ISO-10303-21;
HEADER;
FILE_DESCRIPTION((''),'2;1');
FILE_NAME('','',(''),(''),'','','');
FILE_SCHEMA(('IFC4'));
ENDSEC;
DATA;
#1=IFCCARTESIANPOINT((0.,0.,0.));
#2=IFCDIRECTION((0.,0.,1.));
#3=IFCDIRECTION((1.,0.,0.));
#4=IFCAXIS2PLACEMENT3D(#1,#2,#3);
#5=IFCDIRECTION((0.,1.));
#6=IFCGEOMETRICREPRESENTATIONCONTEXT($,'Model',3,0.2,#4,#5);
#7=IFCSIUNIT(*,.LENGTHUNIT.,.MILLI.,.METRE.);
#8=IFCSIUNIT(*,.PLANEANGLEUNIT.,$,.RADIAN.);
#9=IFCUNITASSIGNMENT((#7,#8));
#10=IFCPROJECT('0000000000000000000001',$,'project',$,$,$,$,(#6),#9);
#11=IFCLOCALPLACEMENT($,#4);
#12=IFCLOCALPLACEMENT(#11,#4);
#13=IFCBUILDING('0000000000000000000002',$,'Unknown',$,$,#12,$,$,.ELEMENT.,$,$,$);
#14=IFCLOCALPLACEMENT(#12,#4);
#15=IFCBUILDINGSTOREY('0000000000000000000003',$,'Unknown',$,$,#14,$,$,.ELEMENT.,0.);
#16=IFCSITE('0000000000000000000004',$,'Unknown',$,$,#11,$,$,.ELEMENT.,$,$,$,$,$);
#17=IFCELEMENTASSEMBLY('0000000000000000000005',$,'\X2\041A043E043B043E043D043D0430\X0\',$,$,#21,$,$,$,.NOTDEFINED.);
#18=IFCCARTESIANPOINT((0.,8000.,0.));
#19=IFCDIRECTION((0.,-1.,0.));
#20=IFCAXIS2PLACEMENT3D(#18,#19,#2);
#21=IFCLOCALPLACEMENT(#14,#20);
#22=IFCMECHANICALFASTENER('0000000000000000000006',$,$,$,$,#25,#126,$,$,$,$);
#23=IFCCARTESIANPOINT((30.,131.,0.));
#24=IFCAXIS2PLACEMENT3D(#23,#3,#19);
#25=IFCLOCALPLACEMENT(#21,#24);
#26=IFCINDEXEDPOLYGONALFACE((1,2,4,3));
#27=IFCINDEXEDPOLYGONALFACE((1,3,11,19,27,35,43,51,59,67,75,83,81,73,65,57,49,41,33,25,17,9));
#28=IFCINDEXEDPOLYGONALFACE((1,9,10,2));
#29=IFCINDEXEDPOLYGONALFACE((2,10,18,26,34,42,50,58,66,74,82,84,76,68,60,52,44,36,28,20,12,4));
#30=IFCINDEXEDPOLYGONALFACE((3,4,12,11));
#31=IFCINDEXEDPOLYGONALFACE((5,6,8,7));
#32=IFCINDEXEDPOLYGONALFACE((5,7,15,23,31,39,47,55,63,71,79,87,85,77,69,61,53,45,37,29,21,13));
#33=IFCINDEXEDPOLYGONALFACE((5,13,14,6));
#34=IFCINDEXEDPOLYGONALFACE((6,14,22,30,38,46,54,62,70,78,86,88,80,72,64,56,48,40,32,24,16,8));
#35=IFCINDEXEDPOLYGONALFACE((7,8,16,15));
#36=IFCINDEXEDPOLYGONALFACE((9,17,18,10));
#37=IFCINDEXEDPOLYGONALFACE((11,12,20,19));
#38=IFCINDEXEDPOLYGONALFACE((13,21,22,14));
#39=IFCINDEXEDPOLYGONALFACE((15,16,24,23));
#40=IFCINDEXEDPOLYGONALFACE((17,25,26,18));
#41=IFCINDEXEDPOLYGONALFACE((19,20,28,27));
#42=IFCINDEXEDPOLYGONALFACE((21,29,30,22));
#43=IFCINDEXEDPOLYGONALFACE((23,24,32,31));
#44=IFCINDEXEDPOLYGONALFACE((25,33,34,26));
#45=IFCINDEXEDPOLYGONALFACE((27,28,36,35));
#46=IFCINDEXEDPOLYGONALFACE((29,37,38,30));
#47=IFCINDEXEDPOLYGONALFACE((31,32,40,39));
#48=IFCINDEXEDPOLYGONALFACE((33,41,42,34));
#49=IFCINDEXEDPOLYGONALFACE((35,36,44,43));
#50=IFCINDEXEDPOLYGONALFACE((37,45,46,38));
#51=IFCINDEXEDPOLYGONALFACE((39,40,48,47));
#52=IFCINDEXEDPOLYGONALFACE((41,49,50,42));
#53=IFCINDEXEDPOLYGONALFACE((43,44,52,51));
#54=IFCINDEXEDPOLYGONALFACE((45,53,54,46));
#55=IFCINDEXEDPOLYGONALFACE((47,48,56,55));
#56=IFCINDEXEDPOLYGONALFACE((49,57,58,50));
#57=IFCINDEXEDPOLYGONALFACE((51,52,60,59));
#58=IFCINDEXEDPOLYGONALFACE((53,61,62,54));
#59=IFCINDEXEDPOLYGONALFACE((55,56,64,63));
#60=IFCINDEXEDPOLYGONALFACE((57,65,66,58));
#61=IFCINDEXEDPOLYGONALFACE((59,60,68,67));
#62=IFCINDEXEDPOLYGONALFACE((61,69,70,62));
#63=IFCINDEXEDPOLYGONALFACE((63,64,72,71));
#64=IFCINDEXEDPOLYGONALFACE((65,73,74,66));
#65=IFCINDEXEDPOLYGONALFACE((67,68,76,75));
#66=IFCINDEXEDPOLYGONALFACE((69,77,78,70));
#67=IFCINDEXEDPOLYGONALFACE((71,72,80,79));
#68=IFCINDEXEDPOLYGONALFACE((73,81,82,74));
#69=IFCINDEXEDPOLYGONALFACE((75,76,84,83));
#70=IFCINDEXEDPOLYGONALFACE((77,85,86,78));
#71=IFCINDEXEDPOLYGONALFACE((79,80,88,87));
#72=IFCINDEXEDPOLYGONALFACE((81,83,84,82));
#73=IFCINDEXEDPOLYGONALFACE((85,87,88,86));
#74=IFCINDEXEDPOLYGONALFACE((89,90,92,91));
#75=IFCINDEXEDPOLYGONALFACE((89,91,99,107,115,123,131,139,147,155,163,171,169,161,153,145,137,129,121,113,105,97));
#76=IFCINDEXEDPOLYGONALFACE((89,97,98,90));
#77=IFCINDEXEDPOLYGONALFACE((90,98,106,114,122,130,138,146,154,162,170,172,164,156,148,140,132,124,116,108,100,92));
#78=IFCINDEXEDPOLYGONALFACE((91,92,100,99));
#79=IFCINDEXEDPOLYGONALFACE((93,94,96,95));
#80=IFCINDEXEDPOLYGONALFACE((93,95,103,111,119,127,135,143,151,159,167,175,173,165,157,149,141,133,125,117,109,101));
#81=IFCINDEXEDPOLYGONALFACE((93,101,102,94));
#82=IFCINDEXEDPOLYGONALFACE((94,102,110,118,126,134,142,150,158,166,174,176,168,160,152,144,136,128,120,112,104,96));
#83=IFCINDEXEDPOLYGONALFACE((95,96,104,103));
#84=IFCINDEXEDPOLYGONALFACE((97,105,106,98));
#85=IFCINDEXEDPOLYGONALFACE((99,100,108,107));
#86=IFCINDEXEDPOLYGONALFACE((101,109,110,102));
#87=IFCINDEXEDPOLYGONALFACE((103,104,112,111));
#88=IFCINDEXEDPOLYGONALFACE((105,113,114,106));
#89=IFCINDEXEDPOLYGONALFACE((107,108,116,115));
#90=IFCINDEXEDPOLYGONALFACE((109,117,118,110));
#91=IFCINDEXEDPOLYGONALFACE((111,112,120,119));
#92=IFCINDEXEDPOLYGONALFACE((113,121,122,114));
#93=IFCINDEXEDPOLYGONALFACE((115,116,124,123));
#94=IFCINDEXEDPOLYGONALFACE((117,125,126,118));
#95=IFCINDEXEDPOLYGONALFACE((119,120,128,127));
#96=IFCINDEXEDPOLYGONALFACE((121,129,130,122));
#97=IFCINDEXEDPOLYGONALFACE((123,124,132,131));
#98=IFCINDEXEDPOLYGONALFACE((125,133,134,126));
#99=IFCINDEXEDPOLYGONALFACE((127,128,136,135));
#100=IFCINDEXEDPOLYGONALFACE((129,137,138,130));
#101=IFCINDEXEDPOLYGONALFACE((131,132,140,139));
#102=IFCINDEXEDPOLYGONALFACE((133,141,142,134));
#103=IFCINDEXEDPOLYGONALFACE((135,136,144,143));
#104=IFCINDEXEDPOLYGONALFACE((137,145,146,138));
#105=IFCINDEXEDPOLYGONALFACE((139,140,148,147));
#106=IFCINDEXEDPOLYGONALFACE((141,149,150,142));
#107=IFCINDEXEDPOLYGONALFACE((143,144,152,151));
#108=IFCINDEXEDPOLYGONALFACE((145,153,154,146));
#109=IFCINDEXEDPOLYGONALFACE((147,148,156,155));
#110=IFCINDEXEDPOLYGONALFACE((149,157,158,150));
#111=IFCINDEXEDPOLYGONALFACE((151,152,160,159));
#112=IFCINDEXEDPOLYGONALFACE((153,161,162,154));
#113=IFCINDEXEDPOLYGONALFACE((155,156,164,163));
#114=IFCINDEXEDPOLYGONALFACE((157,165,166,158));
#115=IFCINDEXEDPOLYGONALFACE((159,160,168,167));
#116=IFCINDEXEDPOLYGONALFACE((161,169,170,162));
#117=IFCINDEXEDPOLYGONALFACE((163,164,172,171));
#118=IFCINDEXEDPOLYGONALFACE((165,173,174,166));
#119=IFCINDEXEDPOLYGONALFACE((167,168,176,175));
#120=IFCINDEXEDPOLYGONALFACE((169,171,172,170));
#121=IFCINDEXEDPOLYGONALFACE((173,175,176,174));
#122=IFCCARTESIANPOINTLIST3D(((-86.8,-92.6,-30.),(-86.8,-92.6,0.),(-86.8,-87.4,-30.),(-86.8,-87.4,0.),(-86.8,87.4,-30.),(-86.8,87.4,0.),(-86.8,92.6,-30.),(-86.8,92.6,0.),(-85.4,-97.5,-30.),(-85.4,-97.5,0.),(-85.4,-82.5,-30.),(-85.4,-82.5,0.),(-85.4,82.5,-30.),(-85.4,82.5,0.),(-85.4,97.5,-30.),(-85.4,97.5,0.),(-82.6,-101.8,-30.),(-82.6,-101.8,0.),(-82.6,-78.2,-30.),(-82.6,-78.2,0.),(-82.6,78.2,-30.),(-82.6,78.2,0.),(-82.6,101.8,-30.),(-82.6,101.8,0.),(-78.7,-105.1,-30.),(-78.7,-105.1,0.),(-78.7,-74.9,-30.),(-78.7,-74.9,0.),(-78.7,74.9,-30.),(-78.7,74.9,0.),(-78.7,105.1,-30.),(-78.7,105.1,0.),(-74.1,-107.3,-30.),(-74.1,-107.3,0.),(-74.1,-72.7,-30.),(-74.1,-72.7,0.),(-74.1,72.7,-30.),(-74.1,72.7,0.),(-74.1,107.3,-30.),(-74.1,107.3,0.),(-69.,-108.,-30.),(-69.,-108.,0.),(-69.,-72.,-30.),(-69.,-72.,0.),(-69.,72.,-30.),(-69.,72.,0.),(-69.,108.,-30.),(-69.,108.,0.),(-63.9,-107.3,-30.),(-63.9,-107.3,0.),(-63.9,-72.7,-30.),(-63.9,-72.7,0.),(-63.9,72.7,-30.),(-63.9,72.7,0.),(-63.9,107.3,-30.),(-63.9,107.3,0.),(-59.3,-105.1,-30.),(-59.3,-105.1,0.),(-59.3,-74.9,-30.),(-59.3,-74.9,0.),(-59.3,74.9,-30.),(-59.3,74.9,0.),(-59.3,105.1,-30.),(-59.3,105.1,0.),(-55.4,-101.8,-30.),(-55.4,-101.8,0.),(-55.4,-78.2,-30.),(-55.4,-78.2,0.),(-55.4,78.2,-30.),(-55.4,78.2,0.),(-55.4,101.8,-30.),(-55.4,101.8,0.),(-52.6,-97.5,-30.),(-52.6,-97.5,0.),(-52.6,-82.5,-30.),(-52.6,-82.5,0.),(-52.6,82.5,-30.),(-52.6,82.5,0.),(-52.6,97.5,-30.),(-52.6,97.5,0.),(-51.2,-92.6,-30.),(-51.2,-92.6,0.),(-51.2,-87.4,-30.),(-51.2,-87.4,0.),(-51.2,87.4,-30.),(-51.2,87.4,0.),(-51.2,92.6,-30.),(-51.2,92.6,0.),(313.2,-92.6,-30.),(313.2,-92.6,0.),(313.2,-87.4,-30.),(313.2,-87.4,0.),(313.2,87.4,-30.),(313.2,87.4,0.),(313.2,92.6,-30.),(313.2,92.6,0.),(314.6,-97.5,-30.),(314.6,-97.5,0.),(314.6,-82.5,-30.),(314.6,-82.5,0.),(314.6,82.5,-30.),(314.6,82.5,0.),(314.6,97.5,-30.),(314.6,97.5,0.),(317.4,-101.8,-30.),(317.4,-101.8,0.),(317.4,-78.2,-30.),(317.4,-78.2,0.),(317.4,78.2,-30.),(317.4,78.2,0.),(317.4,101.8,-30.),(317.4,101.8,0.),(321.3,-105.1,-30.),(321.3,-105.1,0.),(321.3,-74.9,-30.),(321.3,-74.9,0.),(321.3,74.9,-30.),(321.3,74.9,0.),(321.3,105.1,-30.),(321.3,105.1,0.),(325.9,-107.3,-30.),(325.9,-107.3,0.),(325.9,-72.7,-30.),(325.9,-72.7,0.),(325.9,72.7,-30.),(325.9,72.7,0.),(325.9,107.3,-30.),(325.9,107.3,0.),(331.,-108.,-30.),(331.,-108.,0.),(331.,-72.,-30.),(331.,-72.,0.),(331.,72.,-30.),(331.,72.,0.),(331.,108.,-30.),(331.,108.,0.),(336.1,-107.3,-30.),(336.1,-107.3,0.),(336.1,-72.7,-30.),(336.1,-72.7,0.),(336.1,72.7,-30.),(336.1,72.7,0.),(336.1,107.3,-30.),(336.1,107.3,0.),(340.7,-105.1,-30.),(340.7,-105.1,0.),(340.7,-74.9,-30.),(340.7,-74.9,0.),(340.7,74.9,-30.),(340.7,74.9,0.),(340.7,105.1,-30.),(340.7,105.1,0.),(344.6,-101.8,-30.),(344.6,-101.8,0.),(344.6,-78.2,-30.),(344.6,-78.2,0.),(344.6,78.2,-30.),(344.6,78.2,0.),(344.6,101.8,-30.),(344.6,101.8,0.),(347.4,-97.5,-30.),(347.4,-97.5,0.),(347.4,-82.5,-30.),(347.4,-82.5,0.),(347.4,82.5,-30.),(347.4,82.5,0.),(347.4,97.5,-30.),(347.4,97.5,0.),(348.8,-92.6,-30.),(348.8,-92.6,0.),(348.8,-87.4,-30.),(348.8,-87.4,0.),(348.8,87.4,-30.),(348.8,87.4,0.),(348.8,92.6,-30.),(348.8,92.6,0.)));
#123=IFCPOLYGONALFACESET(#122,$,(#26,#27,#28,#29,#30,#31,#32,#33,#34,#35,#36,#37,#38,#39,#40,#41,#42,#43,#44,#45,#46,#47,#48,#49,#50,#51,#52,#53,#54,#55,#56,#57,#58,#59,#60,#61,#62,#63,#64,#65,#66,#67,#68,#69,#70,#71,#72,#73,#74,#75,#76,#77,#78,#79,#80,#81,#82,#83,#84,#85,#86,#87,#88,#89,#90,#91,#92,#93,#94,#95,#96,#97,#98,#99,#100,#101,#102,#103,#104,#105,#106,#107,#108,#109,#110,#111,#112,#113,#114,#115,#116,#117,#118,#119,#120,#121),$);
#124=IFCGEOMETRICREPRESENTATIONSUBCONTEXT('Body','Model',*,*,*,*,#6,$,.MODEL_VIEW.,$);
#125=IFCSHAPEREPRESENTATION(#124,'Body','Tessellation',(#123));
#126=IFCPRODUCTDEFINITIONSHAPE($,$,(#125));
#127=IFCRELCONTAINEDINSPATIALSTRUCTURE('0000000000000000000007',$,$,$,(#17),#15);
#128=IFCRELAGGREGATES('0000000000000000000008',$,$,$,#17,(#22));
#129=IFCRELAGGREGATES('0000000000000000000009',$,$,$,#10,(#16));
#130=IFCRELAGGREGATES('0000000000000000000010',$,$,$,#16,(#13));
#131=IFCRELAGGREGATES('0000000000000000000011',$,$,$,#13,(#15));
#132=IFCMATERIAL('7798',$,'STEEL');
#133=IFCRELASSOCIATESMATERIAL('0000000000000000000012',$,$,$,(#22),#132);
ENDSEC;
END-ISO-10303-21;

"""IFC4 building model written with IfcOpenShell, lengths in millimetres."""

from ifc_helpers import new_model, si_unit, direction, frame, origin_with_axes, place, context, subcontext, project, spatial, arc, indexed_curve, outline, extrude, source, transform, mapped, material, element, aggregate, save


model = new_model("IFC4")

# Units and contexts
model_context = context("Model", 3, precision=0.2, world=origin_with_axes(), true_north=direction((0.0, 1.0)))
body_context = subcontext(model_context, "Body", "Model", "MODEL_VIEW")
ifc_project = project(units=[si_unit("LENGTHUNIT", "METRE", prefix="MILLI"), si_unit("PLANEANGLEUNIT", "RADIAN")], contexts=[model_context])

# Site, building, storey
site_placement = place(None, origin_with_axes())
site = spatial("IfcSite", under=ifc_project, at=site_placement, Name="Unknown", CompositionType="ELEMENT")
building_placement = place(site_placement, origin_with_axes())
building = spatial("IfcBuilding", under=site, at=building_placement, Name="Unknown", CompositionType="ELEMENT")
storey_placement = place(building_placement, origin_with_axes())
storey = spatial("IfcBuildingStorey", under=building, at=storey_placement, Name="Unknown", CompositionType="ELEMENT", Elevation=0.0)

# Element assembly
assembly_1_placement = place(storey_placement, frame((0.0, 8000.0, 0.0), z_axis=(0.0, -1.0, 0.0), x_axis=(0.0, 0.0, 1.0)))
assembly_1 = element("IfcElementAssembly", 1, at=assembly_1_placement, inside=storey, Name="Колонна", PredefinedType="NOTDEFINED")

# Mechanical fastener
ifc_material_1 = material(Name="7798", Category="STEEL")
shared_shape_1 = source(origin_with_axes(), body_context, "Body", "SweptSolid", [
    extrude(outline(indexed_curve([(18.0, 0.0), (0.0, 18.0), (-18.0, 0.0), (0.0, -18.0)], segments=[arc(1, 2, 3), arc(3, 4, 1)])), frame((0.0, 0.0, 0.0), z_axis=(0.0, 0.0, -1.0), x_axis=(0.0, 1.0, 0.0)), (0.0, 0.0, 1.0), 30.0),
])
mechanical_fastener_1_placement = place(assembly_1_placement, frame((30.0, 131.0, 0.0), z_axis=(1.0, 0.0, 0.0), x_axis=(0.0, -1.0, 0.0)))
mechanical_fastener_1 = element("IfcMechanicalFastener", 2, at=mechanical_fastener_1_placement, material=ifc_material_1, context=body_context, shape_type="MappedRepresentation", body=[
    mapped(shared_shape_1, transform((-69.0, -90.0, 0.0))),
    mapped(shared_shape_1, transform((-69.0, 90.0, 0.0))),
    mapped(shared_shape_1, transform((331.0, -90.0, 0.0))),
    mapped(shared_shape_1, transform((331.0, 90.0, 0.0))),
])
aggregate(assembly_1, [mechanical_fastener_1])

save(model, "model.ifc")
